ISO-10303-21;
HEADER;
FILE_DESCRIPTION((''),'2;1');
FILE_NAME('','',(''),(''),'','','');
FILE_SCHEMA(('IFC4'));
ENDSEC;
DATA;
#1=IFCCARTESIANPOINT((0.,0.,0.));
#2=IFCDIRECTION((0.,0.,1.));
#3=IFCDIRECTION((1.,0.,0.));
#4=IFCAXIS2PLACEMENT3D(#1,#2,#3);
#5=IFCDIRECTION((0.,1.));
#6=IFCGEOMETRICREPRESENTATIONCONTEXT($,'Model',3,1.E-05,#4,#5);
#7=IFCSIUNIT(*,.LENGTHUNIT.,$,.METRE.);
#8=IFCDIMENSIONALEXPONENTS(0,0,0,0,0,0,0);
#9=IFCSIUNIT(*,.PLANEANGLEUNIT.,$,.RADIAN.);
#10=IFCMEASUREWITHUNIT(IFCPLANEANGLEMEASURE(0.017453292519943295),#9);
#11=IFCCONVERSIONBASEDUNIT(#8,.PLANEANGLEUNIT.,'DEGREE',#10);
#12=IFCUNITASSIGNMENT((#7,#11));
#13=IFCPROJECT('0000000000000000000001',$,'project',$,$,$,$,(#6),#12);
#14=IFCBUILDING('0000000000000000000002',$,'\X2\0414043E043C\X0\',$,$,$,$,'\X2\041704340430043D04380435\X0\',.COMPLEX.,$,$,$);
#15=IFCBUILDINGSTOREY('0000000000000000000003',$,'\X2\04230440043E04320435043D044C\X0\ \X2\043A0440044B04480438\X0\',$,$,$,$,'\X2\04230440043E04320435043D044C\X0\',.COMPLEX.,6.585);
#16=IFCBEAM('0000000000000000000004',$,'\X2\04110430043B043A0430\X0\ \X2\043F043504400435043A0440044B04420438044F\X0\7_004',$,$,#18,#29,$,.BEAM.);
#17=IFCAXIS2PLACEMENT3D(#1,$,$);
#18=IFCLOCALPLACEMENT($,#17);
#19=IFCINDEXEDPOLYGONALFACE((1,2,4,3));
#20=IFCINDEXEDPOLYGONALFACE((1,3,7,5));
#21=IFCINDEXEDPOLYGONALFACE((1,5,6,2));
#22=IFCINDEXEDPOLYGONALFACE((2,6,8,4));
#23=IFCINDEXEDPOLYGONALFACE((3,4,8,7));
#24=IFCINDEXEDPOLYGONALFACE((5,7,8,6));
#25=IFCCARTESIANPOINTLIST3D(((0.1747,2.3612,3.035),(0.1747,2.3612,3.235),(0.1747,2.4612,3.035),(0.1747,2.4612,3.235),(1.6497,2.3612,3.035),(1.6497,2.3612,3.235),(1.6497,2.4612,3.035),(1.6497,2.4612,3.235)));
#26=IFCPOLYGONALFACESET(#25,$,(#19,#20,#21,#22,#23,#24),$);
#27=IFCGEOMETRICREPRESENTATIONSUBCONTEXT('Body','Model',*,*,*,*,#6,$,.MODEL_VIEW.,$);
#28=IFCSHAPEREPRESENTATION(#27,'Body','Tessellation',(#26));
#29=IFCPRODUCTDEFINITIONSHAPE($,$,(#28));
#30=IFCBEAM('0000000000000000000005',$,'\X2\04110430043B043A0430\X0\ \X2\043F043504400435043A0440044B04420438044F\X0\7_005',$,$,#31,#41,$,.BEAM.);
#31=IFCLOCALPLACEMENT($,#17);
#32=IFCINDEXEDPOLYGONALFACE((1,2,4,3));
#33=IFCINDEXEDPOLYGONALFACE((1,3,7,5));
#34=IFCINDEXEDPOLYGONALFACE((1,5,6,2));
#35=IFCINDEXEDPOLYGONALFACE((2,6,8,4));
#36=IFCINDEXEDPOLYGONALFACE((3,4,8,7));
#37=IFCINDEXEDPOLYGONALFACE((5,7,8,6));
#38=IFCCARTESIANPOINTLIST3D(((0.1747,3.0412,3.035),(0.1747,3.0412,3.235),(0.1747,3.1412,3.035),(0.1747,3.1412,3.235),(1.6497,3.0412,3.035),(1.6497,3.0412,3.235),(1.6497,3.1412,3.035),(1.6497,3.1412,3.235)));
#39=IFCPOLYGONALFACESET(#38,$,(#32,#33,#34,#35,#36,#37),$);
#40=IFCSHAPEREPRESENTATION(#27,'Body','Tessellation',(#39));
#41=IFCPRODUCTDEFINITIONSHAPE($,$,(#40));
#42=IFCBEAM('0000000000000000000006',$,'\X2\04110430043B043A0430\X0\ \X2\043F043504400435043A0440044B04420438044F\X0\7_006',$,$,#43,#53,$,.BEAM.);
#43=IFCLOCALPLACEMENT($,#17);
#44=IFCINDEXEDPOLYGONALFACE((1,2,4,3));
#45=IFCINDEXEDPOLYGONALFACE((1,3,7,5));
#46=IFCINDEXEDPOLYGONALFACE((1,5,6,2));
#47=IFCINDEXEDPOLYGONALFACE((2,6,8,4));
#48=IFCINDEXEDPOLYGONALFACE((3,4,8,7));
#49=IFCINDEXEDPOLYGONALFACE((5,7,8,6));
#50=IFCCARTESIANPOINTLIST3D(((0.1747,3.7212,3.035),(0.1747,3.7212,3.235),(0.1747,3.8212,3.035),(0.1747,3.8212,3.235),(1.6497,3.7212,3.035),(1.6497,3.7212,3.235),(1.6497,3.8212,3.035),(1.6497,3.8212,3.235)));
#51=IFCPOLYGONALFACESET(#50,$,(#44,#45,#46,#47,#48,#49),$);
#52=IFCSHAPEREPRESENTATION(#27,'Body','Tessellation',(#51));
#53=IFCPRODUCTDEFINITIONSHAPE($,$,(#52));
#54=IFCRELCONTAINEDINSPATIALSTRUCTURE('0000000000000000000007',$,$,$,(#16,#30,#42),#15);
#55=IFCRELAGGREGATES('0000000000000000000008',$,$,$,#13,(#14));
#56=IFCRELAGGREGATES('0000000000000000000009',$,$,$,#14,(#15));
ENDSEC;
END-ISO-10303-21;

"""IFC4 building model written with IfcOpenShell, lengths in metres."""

from ifc_helpers import new_model, entity, si_unit, converted_unit, direction, frame, origin_with_axes, origin_2d_with_axis, place, context, subcontext, project, spatial, rectangle, extrude, element, save


model = new_model("IFC4")

# Units and contexts
model_context = context("Model", 3, precision=1e-05, world=origin_with_axes(), true_north=direction((0.0, 1.0)))
body_context = subcontext(model_context, "Body", "Model", "MODEL_VIEW")
ifc_project = project(units=[si_unit("LENGTHUNIT", "METRE"), converted_unit("PLANEANGLEUNIT", "DEGREE", entity("IfcPlaneAngleMeasure", 0.017453292519943295), si_unit("PLANEANGLEUNIT", "RADIAN"), dimensions=[0, 0, 0, 0, 0, 0, 0])], contexts=[model_context])

# Building, storey
building = spatial("IfcBuilding", under=ifc_project, Name="Дом", LongName="Здание", CompositionType="COMPLEX")
storey = spatial("IfcBuildingStorey", under=building, Name="Уровень крыши", LongName="Уровень", CompositionType="COMPLEX", Elevation=6.585)

# Beams
placement = place(None, origin_with_axes())
element("IfcBeam", 1, at=placement, inside=storey, Name="Балка перекрытия7_004", PredefinedType="BEAM", context=body_context, shape_type="SweptSolid", body=[
    extrude(rectangle(XDim=1.475, YDim=0.1, at=origin_2d_with_axis()), frame((0.9122, 2.4112, 3.035), z_axis=(0.0, 0.0, 1.0), x_axis=(1.0, 0.0, 0.0)), (0.0, 0.0, 1.0), 0.2),
])
element("IfcBeam", 2, at=placement, inside=storey, Name="Балка перекрытия7_005", PredefinedType="BEAM", context=body_context, shape_type="SweptSolid", body=[
    extrude(rectangle(XDim=1.475, YDim=0.1, at=origin_2d_with_axis()), frame((0.9122, 3.0912, 3.035), z_axis=(0.0, 0.0, 1.0), x_axis=(1.0, 0.0, 0.0)), (0.0, 0.0, 1.0), 0.2),
])
element("IfcBeam", 3, at=placement, inside=storey, Name="Балка перекрытия7_006", PredefinedType="BEAM", context=body_context, shape_type="SweptSolid", body=[
    extrude(rectangle(XDim=1.475, YDim=0.1, at=origin_2d_with_axis()), frame((0.9122, 3.7712, 3.035), z_axis=(0.0, 0.0, 1.0), x_axis=(1.0, 0.0, 0.0)), (0.0, 0.0, 1.0), 0.2),
])

save(model, "model.ifc")
